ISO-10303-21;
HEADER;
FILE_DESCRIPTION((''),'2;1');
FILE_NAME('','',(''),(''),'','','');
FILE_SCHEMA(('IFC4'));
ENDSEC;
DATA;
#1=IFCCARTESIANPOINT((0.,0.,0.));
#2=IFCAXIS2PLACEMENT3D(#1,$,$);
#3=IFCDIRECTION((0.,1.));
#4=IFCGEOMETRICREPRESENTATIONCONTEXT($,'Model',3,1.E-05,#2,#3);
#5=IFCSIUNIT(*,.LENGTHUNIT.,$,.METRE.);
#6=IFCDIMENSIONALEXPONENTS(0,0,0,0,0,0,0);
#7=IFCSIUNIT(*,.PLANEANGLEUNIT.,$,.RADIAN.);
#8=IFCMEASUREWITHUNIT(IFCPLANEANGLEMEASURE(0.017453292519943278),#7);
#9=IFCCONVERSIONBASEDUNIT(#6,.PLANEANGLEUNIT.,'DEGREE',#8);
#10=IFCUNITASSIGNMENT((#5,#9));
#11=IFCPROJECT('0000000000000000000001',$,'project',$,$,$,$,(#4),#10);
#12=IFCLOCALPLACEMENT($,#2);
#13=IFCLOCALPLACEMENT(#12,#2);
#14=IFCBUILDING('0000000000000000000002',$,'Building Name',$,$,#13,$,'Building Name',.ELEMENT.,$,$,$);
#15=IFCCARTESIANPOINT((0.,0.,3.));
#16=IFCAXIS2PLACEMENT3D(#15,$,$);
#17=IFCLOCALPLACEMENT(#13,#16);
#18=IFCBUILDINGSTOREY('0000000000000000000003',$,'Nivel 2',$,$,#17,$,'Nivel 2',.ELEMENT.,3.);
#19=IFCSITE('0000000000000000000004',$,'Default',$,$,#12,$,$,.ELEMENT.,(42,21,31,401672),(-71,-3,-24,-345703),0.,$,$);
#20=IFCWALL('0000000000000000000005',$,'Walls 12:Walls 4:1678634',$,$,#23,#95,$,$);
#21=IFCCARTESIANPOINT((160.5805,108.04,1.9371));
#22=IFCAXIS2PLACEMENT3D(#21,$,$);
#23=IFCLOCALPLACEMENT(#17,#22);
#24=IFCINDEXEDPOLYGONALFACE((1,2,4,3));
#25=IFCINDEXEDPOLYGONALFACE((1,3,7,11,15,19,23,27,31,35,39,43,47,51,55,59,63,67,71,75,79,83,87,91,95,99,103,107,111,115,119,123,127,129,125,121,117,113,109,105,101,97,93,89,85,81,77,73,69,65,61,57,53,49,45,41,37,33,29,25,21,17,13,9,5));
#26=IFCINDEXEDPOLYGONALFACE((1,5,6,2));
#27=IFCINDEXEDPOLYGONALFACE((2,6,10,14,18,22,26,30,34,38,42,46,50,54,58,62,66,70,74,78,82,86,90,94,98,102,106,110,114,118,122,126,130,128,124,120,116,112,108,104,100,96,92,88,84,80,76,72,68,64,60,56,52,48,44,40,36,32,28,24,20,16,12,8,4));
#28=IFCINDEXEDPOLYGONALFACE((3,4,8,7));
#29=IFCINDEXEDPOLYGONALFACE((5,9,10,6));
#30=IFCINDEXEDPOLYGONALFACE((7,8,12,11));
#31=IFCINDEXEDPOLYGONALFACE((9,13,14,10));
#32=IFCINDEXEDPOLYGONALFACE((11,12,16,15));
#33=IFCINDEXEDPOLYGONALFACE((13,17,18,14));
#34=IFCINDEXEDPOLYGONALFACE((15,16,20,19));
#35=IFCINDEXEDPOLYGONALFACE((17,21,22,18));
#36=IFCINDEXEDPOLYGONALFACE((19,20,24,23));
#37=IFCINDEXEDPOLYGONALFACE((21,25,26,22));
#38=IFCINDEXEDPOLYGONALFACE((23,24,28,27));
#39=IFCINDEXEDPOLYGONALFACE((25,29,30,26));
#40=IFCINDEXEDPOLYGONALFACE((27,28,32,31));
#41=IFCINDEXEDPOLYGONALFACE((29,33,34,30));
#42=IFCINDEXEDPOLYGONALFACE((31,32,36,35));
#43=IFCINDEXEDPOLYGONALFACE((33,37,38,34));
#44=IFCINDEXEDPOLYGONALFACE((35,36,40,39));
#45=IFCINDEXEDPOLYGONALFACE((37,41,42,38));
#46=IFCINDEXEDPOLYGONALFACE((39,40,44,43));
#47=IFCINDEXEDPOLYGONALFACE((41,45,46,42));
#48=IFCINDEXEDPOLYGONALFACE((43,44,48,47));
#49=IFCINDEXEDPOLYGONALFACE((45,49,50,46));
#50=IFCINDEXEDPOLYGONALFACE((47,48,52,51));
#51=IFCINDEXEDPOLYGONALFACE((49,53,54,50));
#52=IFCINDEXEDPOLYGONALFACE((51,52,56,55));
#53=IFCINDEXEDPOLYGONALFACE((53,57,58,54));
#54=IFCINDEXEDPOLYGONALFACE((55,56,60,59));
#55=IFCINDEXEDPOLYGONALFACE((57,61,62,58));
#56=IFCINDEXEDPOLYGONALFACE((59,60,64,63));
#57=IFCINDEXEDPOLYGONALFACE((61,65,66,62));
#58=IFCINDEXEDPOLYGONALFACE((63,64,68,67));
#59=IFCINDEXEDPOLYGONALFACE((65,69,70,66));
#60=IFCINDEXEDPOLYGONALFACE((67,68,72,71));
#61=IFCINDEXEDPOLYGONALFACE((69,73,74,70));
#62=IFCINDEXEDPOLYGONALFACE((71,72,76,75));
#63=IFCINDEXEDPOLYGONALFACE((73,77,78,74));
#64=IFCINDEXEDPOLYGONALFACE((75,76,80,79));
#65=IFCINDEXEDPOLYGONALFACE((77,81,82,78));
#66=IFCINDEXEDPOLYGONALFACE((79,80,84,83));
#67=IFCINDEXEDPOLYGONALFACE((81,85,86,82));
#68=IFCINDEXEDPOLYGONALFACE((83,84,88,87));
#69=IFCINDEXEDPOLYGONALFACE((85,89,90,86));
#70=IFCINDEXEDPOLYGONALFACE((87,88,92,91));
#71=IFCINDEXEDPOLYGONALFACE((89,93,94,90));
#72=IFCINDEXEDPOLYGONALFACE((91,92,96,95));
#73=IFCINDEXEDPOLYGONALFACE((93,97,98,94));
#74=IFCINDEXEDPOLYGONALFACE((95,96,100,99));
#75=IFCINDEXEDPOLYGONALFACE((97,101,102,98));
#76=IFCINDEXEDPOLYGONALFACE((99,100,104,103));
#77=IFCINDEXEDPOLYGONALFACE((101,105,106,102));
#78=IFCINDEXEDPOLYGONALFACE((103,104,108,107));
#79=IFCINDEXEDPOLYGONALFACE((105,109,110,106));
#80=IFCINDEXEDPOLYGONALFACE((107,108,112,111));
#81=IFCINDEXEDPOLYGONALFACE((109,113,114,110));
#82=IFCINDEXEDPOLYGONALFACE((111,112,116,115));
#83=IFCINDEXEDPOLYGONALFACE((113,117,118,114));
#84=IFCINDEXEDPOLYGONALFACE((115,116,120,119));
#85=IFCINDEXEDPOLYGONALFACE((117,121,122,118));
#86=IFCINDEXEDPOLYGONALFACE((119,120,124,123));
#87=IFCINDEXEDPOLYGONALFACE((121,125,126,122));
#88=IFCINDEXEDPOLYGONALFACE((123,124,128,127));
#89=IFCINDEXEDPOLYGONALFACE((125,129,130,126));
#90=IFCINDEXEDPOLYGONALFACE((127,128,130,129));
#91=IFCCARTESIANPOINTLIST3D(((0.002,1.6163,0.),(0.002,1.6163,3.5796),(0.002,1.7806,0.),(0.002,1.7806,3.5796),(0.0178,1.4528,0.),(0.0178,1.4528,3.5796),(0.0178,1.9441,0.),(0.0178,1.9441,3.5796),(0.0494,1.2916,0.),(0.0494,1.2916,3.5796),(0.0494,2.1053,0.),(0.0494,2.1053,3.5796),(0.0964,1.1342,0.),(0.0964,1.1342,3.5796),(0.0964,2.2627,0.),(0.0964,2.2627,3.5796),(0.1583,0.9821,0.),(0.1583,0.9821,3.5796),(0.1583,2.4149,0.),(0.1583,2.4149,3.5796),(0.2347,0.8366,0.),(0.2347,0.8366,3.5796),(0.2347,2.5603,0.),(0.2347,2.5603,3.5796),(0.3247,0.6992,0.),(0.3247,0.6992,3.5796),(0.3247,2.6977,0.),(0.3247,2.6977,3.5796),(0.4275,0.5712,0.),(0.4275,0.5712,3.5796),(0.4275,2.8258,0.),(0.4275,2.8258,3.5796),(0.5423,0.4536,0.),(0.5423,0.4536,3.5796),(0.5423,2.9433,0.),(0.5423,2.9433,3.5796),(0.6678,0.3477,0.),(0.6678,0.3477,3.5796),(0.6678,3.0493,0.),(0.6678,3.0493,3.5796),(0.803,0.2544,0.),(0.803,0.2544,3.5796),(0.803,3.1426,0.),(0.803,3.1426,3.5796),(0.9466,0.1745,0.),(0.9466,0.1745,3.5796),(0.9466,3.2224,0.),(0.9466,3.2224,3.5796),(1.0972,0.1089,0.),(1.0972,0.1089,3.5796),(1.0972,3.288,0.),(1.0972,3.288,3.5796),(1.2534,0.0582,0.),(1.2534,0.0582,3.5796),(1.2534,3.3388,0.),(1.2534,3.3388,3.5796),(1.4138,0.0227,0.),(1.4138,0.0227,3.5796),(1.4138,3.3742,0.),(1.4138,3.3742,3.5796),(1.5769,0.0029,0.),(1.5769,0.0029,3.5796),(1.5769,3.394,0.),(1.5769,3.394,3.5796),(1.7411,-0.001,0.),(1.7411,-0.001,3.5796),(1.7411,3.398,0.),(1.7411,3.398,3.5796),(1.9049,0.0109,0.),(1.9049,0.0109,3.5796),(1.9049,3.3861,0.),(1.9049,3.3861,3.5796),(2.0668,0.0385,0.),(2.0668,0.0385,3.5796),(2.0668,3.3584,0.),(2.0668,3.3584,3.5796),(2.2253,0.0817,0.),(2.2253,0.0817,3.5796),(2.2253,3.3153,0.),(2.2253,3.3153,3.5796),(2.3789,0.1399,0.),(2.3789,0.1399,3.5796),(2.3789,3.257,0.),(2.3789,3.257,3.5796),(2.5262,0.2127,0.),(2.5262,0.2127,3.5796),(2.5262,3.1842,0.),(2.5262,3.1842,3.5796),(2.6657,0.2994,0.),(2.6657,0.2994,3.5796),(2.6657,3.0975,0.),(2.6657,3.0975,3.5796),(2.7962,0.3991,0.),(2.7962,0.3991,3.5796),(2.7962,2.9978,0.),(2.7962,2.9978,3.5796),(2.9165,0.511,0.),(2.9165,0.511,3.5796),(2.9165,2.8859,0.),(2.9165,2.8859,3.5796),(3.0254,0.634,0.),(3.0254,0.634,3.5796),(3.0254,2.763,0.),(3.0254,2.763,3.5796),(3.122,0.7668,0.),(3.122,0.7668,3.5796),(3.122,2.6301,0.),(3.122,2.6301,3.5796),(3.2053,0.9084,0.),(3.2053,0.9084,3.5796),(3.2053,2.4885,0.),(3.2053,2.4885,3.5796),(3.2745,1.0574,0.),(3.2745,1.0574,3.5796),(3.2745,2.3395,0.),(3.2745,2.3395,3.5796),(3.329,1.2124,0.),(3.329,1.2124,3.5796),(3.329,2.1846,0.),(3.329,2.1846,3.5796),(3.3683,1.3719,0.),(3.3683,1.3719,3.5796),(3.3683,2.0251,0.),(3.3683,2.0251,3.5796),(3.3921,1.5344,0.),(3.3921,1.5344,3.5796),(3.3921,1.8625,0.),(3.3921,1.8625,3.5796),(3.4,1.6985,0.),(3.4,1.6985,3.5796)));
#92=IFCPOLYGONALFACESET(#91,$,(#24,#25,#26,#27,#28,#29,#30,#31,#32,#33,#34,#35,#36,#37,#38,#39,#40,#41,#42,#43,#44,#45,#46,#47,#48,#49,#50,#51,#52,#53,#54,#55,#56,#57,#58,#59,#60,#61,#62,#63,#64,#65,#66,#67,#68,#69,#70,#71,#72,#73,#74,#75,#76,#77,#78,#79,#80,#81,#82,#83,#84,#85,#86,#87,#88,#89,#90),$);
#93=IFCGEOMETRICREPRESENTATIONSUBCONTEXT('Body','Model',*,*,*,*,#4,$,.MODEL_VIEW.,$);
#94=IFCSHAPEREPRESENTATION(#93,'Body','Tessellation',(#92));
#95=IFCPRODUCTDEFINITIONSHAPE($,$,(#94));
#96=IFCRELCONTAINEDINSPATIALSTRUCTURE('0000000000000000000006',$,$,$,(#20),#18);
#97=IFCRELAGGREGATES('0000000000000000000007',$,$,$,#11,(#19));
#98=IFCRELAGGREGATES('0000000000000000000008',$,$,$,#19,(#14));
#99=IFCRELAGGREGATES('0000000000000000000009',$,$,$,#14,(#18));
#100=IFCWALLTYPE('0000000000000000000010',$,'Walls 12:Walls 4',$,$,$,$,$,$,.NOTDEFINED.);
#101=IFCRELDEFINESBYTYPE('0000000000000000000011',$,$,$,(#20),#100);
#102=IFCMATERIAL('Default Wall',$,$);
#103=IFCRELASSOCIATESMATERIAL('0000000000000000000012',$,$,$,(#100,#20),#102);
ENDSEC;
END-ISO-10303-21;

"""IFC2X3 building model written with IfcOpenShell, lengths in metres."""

from ifc_helpers import new_model, entity, si_unit, converted_unit, direction, frame, origin, origin_2d_with_axis, place, context, subcontext, project, spatial, circle, extrude, material, type_object, element, save


model = new_model("IFC2X3")

# Units and contexts
model_context = context("Model", 3, precision=1e-05, world=origin(), true_north=direction((0.0, 1.0)))
body_context = subcontext(model_context, "Body", "Model", "MODEL_VIEW")
ifc_project = project(units=[si_unit("LENGTHUNIT", "METRE"), converted_unit("PLANEANGLEUNIT", "DEGREE", entity("IfcPlaneAngleMeasure", 0.017453292519943278), si_unit("PLANEANGLEUNIT", "RADIAN"), dimensions=[0, 0, 0, 0, 0, 0, 0])], contexts=[model_context])

# Site, building, storey
site_placement = place(None, origin())
site = spatial("IfcSite", under=ifc_project, at=site_placement, Name="Default", CompositionType="ELEMENT", RefLatitude=(42, 21, 31, 401672), RefLongitude=(-71, -3, -24, -345703), RefElevation=0.0)
building_placement = place(site_placement, origin())
building = spatial("IfcBuilding", under=site, at=building_placement, Name="Building Name", LongName="Building Name", CompositionType="ELEMENT")
storey_placement = place(building_placement, frame((0.0, 0.0, 3.0)))
storey = spatial("IfcBuildingStorey", under=building, at=storey_placement, Name="Nivel 2", LongName="Nivel 2", CompositionType="ELEMENT", Elevation=3.0)

# Wall
ifc_material_1 = material(Name="Default Wall")
wall_type_1 = type_object("IfcWallType", Name="Walls 12:Walls 4", PredefinedType="NOTDEFINED", material=ifc_material_1)
wall_1_placement = place(storey_placement, frame((160.5805, 108.04, 1.9371)))
element("IfcWall", 1, at=wall_1_placement, inside=storey, type_object=wall_type_1, material=ifc_material_1, Name="Walls 12:Walls 4:1678634", context=body_context, shape_type="SweptSolid", body=[
    extrude(circle(Radius=1.7, at=origin_2d_with_axis()), frame((1.7, 1.6985, 0.0)), (0.0, 0.0, 1.0), 3.5796),
])

save(model, "model.ifc")
